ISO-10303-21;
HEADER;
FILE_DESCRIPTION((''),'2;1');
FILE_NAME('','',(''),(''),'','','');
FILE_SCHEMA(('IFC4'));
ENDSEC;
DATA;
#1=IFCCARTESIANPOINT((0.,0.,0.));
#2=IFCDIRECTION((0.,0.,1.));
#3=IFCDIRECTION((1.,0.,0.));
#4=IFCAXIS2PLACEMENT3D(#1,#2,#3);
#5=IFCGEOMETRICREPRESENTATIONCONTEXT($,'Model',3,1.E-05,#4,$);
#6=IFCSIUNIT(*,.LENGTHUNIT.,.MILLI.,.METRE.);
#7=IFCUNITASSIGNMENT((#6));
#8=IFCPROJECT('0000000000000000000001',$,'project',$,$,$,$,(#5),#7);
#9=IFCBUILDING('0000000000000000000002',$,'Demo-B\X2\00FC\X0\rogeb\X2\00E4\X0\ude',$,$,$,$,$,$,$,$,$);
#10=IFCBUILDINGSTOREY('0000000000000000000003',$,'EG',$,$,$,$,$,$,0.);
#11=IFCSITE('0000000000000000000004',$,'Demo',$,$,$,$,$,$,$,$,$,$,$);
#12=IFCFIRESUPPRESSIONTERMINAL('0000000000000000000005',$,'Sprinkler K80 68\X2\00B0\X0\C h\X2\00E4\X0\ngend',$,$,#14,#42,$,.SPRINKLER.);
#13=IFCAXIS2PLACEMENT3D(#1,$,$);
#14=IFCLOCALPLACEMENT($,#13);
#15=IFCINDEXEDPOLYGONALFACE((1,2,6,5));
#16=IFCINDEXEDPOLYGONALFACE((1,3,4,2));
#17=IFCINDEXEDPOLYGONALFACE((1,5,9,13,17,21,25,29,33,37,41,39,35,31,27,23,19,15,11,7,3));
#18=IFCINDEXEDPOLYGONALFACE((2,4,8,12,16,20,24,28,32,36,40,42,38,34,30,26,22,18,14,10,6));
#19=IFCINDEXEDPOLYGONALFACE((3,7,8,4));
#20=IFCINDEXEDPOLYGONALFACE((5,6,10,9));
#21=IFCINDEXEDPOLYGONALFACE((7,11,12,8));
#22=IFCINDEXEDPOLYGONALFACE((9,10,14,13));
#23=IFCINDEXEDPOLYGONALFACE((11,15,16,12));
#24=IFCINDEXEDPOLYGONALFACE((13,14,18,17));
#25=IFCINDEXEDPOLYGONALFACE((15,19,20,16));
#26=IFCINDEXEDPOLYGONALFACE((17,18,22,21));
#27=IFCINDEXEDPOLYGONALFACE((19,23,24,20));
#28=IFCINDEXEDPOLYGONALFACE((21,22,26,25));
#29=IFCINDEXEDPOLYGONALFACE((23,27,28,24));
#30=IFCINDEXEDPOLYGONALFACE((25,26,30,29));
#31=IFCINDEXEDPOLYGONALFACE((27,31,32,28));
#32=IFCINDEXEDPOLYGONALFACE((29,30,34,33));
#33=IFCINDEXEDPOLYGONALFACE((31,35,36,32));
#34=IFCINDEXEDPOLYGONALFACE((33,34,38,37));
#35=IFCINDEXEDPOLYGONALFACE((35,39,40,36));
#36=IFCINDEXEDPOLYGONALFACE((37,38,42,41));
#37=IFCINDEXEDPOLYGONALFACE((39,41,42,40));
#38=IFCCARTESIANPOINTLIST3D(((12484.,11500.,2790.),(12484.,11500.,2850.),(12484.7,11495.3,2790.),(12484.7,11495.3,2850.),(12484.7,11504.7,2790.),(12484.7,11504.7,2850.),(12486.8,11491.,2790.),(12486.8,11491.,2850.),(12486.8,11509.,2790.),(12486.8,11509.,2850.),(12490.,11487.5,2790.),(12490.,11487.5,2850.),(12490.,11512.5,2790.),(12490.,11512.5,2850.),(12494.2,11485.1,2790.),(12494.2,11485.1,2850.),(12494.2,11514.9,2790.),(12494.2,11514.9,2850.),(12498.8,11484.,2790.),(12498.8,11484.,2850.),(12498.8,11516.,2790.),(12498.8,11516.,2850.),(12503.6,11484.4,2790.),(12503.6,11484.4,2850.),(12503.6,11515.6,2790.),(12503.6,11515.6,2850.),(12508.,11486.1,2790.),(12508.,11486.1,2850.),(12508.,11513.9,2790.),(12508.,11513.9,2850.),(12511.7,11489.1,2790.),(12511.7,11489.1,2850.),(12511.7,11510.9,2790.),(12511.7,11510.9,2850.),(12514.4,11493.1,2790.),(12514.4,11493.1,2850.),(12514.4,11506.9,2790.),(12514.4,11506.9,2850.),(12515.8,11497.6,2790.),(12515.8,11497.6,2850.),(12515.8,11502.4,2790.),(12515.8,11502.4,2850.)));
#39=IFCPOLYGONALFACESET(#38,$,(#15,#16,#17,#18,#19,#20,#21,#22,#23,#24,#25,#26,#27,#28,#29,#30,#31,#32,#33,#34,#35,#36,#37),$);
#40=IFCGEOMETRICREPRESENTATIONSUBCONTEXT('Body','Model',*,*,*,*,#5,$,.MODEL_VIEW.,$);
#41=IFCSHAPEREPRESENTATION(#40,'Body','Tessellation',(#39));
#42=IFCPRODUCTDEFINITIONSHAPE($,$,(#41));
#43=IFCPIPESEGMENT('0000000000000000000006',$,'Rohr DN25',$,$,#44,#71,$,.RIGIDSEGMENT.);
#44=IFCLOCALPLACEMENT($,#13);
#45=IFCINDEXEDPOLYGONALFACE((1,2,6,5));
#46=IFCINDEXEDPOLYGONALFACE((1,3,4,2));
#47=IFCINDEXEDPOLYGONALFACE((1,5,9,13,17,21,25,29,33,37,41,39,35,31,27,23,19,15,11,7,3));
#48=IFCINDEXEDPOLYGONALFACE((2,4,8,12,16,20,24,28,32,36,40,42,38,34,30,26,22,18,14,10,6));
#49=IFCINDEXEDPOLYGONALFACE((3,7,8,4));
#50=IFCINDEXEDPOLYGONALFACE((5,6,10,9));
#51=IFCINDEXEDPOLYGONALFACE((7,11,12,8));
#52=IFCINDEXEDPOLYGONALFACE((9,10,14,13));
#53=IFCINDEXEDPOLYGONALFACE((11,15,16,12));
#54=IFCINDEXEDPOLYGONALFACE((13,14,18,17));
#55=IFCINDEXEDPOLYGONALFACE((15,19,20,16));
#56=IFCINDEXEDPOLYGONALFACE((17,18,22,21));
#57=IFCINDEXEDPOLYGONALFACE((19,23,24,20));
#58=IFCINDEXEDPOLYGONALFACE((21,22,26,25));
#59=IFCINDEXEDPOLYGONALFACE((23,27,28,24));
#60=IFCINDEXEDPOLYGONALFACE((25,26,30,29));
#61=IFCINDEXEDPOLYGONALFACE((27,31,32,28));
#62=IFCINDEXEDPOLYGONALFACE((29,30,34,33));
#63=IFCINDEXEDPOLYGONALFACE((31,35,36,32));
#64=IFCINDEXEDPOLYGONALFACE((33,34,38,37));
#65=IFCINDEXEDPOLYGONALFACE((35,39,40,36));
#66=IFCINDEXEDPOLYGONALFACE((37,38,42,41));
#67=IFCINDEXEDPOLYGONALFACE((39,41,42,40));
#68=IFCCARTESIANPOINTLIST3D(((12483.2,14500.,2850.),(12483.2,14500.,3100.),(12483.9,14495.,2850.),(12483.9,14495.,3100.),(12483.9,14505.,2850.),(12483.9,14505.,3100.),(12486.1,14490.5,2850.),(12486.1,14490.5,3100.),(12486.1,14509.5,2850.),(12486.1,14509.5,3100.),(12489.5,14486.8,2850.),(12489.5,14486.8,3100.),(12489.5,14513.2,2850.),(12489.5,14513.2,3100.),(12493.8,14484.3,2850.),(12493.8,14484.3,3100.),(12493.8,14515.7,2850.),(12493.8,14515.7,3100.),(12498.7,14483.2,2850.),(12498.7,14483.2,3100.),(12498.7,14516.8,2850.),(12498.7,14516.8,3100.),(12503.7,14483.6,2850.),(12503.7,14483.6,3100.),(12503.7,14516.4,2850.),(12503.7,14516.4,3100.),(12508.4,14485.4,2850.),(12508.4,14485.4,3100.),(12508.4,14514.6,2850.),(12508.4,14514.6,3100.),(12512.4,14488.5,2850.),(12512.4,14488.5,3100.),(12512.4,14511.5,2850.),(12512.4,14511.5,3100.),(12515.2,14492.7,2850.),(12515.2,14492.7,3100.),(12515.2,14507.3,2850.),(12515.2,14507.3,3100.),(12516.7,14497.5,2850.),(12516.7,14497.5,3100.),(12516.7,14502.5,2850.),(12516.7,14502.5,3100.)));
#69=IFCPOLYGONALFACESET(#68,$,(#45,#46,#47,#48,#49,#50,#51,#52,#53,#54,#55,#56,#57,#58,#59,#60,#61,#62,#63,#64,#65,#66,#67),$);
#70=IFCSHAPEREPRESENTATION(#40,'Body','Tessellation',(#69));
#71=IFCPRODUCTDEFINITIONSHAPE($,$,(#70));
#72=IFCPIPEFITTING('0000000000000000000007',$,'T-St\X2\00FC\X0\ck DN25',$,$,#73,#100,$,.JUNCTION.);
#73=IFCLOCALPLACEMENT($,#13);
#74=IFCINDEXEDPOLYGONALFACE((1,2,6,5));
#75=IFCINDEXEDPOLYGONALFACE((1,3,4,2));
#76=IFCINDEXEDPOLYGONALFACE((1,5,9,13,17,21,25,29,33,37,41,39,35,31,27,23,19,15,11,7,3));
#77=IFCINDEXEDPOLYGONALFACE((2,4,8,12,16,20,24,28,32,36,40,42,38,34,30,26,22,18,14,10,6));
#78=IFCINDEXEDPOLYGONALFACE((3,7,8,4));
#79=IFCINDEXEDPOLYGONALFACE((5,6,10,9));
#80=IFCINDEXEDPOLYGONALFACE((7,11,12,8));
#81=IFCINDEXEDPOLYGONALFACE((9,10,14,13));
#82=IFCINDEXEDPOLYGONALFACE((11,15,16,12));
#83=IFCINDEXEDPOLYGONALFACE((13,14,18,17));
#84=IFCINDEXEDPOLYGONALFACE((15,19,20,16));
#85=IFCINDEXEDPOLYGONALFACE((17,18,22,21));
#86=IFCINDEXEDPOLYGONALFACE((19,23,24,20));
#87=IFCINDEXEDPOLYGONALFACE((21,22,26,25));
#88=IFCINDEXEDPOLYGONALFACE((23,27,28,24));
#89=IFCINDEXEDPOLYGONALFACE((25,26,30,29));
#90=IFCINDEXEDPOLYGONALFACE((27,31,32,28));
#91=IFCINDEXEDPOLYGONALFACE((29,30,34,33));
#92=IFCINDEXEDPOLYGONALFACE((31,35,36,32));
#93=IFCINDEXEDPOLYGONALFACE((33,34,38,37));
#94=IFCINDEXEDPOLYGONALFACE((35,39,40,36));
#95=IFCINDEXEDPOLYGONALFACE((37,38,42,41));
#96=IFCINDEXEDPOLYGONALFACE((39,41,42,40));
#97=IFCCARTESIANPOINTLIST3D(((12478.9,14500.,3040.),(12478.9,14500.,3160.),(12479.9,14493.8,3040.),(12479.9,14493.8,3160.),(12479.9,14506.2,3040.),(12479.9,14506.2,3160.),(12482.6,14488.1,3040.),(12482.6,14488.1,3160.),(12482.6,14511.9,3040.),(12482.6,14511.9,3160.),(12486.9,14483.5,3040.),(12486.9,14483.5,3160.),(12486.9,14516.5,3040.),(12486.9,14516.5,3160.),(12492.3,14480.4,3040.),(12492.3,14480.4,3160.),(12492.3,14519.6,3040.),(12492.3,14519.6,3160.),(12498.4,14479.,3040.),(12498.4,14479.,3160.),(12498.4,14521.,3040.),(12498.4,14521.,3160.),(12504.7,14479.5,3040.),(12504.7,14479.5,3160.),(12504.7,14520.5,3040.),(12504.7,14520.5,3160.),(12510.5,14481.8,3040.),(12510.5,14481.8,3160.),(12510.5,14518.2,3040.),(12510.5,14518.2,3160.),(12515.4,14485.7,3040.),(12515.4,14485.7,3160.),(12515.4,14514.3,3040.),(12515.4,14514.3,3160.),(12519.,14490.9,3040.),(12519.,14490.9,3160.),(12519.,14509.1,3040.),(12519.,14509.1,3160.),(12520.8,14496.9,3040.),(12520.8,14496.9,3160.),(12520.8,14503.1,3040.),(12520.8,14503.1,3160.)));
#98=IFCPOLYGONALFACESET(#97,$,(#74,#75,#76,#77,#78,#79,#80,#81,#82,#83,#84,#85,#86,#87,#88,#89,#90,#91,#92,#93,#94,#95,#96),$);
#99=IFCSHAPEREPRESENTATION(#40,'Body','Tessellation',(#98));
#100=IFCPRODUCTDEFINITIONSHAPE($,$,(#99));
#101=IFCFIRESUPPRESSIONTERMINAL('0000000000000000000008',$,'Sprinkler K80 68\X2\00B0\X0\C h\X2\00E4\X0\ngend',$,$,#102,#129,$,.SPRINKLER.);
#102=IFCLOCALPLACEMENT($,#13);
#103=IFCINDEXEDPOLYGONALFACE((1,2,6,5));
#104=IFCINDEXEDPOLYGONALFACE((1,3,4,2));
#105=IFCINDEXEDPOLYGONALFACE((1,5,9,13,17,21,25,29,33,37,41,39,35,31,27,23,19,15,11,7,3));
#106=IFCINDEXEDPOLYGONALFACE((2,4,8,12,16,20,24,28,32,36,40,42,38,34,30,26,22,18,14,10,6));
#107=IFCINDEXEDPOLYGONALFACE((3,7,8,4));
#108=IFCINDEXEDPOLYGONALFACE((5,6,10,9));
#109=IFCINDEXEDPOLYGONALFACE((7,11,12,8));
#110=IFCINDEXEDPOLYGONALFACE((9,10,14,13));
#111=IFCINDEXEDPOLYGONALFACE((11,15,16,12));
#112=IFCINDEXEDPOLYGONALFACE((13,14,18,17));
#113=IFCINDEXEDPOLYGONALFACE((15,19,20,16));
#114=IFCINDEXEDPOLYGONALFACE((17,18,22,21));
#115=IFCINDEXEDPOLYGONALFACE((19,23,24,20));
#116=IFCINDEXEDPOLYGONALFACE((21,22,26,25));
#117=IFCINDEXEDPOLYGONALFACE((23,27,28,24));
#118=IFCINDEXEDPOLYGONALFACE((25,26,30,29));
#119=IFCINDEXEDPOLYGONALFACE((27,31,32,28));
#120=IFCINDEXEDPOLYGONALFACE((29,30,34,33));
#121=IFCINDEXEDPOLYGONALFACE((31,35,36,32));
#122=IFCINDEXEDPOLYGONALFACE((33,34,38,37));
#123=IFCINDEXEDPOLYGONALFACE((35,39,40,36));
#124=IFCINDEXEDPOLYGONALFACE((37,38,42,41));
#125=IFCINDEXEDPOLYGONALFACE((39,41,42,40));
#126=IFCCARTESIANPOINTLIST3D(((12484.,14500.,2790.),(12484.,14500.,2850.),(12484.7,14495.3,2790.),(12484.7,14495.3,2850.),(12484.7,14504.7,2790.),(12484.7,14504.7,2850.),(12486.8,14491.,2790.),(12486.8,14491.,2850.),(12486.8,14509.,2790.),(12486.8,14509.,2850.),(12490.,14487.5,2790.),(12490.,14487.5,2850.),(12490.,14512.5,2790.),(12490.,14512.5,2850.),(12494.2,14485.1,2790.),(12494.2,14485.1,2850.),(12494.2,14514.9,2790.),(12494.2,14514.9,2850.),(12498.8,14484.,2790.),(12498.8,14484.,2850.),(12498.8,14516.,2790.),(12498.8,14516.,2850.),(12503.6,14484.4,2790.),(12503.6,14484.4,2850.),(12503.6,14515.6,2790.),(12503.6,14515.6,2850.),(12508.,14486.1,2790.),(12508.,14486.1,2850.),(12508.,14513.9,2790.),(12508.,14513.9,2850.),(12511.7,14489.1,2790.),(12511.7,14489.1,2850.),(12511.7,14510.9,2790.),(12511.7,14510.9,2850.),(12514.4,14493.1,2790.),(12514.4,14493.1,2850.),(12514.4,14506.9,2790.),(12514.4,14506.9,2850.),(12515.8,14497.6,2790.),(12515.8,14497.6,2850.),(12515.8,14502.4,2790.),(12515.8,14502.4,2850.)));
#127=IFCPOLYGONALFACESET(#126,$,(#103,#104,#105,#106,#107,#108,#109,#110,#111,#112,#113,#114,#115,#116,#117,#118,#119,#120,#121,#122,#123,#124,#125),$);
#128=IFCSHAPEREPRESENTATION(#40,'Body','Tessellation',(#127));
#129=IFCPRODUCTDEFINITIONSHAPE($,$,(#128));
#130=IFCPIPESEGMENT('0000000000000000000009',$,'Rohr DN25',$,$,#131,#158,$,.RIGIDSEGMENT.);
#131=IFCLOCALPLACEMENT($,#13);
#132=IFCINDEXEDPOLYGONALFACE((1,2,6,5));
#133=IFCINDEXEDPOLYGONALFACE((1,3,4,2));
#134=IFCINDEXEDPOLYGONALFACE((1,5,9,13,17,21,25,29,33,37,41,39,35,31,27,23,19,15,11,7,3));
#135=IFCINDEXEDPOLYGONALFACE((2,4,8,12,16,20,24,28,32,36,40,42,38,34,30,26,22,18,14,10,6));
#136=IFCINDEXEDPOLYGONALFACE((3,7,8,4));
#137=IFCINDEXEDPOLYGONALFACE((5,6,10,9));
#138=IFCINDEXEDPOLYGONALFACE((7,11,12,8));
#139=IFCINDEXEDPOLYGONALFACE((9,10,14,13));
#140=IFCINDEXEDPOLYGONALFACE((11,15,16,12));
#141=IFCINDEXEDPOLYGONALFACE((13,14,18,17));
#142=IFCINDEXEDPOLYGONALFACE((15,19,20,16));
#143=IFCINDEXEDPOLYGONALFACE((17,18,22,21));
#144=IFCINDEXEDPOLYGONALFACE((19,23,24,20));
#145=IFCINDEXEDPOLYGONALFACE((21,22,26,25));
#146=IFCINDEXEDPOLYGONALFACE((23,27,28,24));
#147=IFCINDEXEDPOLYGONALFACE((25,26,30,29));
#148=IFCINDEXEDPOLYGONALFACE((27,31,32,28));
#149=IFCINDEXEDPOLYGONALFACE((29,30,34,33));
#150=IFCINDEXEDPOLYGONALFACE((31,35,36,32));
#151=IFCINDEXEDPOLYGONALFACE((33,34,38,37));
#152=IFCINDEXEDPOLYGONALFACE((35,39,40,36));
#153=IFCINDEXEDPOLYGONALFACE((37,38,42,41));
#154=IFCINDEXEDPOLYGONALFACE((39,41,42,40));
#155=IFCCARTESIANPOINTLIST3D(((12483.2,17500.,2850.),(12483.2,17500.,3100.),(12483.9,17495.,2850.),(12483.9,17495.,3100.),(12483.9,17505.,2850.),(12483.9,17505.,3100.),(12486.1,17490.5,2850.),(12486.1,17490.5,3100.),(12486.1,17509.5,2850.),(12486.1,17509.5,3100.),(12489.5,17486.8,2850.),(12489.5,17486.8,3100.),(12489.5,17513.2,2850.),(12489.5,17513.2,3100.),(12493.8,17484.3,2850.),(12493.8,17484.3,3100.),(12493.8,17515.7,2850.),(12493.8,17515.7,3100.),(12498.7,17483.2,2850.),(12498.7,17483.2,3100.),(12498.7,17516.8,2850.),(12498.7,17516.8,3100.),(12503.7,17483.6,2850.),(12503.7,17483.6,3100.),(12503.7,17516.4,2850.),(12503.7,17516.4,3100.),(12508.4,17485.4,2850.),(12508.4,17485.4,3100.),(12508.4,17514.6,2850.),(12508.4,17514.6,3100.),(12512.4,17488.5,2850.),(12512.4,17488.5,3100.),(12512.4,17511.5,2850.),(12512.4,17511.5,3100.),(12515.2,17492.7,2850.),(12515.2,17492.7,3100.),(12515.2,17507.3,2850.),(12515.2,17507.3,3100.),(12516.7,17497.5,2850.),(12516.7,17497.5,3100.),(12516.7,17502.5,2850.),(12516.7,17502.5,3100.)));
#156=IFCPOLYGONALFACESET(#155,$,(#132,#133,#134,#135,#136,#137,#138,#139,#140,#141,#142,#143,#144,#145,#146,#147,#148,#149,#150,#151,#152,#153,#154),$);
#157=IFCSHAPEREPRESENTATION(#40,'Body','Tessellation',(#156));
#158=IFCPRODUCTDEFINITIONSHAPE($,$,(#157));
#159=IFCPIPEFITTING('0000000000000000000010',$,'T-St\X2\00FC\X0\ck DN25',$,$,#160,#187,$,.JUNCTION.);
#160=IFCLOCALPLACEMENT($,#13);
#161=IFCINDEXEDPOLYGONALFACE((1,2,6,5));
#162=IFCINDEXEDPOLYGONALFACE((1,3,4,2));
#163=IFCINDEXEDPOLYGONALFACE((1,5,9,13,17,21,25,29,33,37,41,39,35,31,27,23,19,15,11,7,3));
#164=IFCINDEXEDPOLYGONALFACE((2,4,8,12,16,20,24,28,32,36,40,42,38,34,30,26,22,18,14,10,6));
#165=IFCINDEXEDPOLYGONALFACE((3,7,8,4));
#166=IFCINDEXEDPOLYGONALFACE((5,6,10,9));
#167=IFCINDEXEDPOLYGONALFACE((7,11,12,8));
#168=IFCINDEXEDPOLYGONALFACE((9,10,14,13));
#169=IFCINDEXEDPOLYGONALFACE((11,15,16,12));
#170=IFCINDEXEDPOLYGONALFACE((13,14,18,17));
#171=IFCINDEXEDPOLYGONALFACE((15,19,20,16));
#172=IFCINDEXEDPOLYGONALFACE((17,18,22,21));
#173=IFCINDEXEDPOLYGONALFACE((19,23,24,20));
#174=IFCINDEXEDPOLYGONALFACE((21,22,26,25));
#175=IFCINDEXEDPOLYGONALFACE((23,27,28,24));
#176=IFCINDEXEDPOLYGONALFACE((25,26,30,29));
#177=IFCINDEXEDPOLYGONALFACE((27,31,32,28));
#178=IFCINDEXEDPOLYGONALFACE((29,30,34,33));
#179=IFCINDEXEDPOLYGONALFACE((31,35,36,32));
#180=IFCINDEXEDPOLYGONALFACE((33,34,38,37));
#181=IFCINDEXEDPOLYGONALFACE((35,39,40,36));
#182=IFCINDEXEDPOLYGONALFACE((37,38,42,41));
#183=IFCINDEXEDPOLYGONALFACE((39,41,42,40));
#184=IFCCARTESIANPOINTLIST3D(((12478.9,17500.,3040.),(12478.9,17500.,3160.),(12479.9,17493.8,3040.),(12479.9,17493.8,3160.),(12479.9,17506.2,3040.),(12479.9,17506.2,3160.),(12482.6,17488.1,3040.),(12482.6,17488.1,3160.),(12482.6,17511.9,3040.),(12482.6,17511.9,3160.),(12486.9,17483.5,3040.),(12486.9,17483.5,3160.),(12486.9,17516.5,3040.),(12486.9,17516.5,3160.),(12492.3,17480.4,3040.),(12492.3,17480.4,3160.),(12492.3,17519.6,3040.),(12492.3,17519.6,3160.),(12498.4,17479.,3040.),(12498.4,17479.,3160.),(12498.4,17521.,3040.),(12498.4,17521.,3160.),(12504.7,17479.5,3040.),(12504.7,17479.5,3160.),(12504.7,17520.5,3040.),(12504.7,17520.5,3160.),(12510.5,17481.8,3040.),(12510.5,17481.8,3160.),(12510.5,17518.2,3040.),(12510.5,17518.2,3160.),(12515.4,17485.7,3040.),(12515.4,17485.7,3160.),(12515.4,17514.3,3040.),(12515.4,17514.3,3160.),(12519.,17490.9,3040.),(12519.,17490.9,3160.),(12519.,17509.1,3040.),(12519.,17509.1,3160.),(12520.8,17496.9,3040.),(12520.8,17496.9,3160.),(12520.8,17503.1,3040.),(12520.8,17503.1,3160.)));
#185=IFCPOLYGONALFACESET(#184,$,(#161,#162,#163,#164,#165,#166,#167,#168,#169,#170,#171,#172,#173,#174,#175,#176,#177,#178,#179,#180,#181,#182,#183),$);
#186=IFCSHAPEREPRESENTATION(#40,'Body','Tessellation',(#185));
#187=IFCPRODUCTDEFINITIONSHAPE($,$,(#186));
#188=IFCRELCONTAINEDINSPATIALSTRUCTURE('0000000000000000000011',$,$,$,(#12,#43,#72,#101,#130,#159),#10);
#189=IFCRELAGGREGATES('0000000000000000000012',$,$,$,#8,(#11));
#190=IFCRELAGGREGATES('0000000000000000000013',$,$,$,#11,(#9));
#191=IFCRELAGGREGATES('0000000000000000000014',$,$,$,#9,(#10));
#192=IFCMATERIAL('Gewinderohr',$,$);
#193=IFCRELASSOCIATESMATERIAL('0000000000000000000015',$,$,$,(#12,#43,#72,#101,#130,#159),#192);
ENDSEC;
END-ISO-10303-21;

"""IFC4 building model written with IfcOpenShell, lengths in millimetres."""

from ifc_helpers import new_model, si_unit, frame, origin_with_axes, place, context, subcontext, project, spatial, circle, extrude, material, element, save


model = new_model("IFC4")

# Units and contexts
model_context = context("Model", 3, precision=1e-05, world=origin_with_axes())
body_context = subcontext(model_context, "Body", "Model", "MODEL_VIEW")
ifc_project = project(units=[si_unit("LENGTHUNIT", "METRE", prefix="MILLI")], contexts=[model_context])

# Site, building, storey
site = spatial("IfcSite", under=ifc_project, Name="Demo")
building = spatial("IfcBuilding", under=site, Name="Demo-Bürogebäude")
storey = spatial("IfcBuildingStorey", under=building, Name="EG", Elevation=0.0)

# Shared definitions
ifc_material_1 = material(Name="Gewinderohr")

# Fire suppression terminal
fire_suppression_terminal_1_placement = place(None, frame((12500.0, 11500.0, 2850.0), z_axis=(0.0, 0.0, -1.0), x_axis=(-1.0, 0.0, 0.0)))
element("IfcFireSuppressionTerminal", 1, at=fire_suppression_terminal_1_placement, inside=storey, material=ifc_material_1, Name="Sprinkler K80 68°C hängend", PredefinedType="SPRINKLER", context=body_context, shape_type="SweptSolid", body=[
    extrude(circle(Radius=16.0), origin_with_axes(), (0.0, 0.0, 1.0), 60.0),
])

# Pipe segment
pipe_segment_1_placement = place(None, frame((12500.0, 14500.0, 3100.0), z_axis=(0.0, 0.0, -1.0), x_axis=(-1.0, 0.0, 0.0)))
element("IfcPipeSegment", 2, at=pipe_segment_1_placement, inside=storey, material=ifc_material_1, Name="Rohr DN25", PredefinedType="RIGIDSEGMENT", context=body_context, shape_type="SweptSolid", body=[
    extrude(circle(Radius=16.9), origin_with_axes(), (0.0, 0.0, 1.0), 250.0),
])

# Pipe fitting
pipe_fitting_1_placement = place(None, frame((12500.0, 14500.0, 3160.0), z_axis=(0.0, 0.0, -1.0), x_axis=(-1.0, 0.0, 0.0)))
element("IfcPipeFitting", 3, at=pipe_fitting_1_placement, inside=storey, material=ifc_material_1, Name="T-Stück DN25", PredefinedType="JUNCTION", context=body_context, shape_type="SweptSolid", body=[
    extrude(circle(Radius=21.1), origin_with_axes(), (0.0, 0.0, 1.0), 120.0),
])

# Fire suppression terminal
fire_suppression_terminal_2_placement = place(None, frame((12500.0, 14500.0, 2850.0), z_axis=(0.0, 0.0, -1.0), x_axis=(-1.0, 0.0, 0.0)))
element("IfcFireSuppressionTerminal", 4, at=fire_suppression_terminal_2_placement, inside=storey, material=ifc_material_1, Name="Sprinkler K80 68°C hängend", PredefinedType="SPRINKLER", context=body_context, shape_type="SweptSolid", body=[
    extrude(circle(Radius=16.0), origin_with_axes(), (0.0, 0.0, 1.0), 60.0),
])

# Pipe segment
pipe_segment_2_placement = place(None, frame((12500.0, 17500.0, 3100.0), z_axis=(0.0, 0.0, -1.0), x_axis=(-1.0, 0.0, 0.0)))
element("IfcPipeSegment", 5, at=pipe_segment_2_placement, inside=storey, material=ifc_material_1, Name="Rohr DN25", PredefinedType="RIGIDSEGMENT", context=body_context, shape_type="SweptSolid", body=[
    extrude(circle(Radius=16.9), origin_with_axes(), (0.0, 0.0, 1.0), 250.0),
])

# Pipe fitting
pipe_fitting_2_placement = place(None, frame((12500.0, 17500.0, 3160.0), z_axis=(0.0, 0.0, -1.0), x_axis=(-1.0, 0.0, 0.0)))
element("IfcPipeFitting", 6, at=pipe_fitting_2_placement, inside=storey, material=ifc_material_1, Name="T-Stück DN25", PredefinedType="JUNCTION", context=body_context, shape_type="SweptSolid", body=[
    extrude(circle(Radius=21.1), origin_with_axes(), (0.0, 0.0, 1.0), 120.0),
])

save(model, "model.ifc")
